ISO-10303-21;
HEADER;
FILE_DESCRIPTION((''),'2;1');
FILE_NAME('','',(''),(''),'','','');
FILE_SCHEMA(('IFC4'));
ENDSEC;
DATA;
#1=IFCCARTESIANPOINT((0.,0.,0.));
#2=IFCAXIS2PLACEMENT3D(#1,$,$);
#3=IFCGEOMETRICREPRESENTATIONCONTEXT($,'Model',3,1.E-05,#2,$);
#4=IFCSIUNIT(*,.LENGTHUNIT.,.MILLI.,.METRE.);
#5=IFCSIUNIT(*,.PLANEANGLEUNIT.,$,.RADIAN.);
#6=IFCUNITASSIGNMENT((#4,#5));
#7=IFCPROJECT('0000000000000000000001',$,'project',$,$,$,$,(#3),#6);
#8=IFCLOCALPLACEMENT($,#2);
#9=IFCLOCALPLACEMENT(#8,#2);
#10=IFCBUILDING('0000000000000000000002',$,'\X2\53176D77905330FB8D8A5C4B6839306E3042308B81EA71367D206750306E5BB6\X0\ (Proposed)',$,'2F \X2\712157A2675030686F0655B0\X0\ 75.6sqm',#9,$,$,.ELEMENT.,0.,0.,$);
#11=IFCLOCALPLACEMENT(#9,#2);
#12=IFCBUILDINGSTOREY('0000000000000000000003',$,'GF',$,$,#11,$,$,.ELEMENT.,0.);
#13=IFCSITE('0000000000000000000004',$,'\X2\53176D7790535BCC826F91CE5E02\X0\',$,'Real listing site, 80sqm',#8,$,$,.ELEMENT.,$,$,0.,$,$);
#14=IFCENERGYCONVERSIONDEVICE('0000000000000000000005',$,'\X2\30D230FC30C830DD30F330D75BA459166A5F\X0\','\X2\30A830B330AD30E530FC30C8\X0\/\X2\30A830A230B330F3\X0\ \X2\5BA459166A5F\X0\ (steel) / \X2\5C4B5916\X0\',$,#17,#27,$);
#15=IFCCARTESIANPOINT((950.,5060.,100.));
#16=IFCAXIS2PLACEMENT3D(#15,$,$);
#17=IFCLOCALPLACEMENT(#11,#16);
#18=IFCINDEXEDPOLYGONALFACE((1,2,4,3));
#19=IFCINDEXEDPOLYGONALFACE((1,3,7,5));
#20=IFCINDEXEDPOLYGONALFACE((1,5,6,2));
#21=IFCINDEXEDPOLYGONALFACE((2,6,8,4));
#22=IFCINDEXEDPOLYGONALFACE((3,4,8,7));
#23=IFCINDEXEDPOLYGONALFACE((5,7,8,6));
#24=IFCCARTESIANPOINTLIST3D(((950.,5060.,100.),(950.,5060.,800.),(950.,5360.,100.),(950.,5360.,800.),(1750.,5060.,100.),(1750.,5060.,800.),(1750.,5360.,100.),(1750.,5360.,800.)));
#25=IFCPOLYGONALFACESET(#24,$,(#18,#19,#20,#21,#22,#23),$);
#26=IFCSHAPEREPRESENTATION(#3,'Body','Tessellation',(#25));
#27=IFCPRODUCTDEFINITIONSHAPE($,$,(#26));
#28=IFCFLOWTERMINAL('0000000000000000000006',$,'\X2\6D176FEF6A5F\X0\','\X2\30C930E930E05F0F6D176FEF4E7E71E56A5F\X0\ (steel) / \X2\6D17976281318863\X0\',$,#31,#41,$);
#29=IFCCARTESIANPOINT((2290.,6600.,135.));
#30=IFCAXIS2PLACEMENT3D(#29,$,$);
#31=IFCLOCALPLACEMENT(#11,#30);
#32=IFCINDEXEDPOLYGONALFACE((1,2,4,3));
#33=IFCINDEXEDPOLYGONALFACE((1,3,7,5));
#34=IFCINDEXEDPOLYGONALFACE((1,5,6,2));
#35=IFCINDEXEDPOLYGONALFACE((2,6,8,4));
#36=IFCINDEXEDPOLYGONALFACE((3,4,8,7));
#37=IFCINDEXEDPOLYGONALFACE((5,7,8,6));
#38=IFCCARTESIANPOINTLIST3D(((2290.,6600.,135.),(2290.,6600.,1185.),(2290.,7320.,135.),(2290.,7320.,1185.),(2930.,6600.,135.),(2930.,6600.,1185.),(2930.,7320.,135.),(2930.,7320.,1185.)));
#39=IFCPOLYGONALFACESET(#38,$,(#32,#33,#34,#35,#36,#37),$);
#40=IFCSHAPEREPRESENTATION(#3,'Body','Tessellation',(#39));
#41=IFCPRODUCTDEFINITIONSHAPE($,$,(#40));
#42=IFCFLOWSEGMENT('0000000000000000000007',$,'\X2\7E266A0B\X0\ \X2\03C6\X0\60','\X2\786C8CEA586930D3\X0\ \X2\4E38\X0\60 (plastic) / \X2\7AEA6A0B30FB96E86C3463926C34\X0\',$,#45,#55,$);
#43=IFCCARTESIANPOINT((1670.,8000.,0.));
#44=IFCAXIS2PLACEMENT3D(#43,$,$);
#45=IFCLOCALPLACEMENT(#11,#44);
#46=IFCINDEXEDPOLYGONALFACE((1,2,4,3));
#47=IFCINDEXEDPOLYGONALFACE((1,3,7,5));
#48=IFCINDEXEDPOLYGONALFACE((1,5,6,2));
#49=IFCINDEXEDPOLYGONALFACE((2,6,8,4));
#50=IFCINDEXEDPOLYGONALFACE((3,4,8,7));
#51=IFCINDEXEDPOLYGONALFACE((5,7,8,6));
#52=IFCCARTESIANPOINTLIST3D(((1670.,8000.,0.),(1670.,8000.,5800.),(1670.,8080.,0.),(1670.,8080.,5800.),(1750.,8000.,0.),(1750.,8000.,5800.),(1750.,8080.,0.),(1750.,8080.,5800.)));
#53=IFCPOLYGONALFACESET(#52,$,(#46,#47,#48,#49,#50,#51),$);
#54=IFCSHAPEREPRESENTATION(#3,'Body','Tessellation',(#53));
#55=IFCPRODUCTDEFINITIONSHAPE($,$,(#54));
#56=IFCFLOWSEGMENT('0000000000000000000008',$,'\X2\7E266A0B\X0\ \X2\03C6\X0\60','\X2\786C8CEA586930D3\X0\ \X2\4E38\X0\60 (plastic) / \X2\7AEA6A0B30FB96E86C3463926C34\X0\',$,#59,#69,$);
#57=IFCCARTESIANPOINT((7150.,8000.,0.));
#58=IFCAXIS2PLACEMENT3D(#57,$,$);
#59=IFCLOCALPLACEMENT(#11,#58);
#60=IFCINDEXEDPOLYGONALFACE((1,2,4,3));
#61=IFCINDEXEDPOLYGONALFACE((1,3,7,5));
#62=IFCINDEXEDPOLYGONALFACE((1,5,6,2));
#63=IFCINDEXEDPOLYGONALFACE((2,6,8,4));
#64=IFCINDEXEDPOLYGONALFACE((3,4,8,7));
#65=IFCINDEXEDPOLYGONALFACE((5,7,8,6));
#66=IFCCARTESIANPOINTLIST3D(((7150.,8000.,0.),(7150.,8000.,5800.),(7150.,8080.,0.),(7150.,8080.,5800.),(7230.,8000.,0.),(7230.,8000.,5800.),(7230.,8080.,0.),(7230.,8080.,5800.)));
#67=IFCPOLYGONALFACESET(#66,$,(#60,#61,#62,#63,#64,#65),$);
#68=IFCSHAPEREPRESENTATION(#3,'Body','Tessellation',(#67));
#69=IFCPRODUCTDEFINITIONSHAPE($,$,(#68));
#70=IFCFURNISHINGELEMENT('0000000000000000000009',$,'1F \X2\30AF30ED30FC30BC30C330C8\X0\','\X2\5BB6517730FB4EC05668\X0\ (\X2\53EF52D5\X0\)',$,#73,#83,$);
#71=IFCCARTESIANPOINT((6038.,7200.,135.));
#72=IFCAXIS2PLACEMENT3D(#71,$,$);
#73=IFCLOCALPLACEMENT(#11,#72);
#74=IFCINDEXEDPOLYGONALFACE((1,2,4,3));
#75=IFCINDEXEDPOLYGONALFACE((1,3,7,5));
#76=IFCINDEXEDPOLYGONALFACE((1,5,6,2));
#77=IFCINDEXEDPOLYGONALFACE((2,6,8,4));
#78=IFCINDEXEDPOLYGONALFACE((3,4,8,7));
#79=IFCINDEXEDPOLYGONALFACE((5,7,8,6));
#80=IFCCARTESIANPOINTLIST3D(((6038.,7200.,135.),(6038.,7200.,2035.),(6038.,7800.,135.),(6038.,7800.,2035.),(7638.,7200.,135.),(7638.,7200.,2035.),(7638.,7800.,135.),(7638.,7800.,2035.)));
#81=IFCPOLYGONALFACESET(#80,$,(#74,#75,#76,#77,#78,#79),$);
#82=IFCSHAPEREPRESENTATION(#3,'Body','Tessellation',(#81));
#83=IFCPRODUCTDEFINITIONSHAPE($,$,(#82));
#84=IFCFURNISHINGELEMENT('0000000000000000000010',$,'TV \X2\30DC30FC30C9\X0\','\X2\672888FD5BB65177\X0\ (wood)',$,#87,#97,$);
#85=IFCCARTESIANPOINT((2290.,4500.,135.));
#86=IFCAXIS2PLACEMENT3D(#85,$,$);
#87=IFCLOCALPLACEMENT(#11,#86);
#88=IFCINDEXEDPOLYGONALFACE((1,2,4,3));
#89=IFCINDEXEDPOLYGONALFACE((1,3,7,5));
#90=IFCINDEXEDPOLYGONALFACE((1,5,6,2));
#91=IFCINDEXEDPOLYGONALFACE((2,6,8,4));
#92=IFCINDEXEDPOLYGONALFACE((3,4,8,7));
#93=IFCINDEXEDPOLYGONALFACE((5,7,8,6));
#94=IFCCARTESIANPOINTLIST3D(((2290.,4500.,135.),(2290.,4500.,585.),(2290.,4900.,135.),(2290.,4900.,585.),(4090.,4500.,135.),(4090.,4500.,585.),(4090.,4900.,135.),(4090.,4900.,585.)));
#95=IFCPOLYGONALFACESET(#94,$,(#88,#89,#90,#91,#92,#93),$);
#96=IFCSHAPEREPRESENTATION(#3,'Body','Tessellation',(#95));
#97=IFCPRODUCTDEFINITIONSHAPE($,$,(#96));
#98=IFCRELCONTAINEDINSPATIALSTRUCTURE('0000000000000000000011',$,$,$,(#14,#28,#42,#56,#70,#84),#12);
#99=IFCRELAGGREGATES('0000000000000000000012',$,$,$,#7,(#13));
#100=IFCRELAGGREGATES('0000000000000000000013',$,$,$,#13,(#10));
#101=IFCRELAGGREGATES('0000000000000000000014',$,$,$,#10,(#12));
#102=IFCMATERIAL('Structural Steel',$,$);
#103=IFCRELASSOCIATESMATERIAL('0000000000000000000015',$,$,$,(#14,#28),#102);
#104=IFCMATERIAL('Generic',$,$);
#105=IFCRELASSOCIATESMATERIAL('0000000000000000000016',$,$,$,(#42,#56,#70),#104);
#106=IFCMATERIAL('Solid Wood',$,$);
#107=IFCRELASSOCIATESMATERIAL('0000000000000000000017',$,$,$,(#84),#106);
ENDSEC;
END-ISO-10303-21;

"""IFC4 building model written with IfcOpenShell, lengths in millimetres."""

from ifc_helpers import new_model, si_unit, frame, frame_2d, origin, place, context, project, spatial, rectangle, extrude, material, element, save


model = new_model("IFC4")

# Units and contexts
model_context = context("Model", 3, precision=1e-05, world=origin())
ifc_project = project(units=[si_unit("LENGTHUNIT", "METRE", prefix="MILLI"), si_unit("PLANEANGLEUNIT", "RADIAN")], contexts=[model_context])

# Site, building, storey
site_placement = place(None, origin())
site = spatial("IfcSite", under=ifc_project, at=site_placement, Name="北海道富良野市", ObjectType="Real listing site, 80sqm", CompositionType="ELEMENT", RefElevation=0.0)
building_placement = place(site_placement, origin())
building = spatial("IfcBuilding", under=site, at=building_placement, Name="北海道・越屋根のある自然素材の家 (Proposed)", ObjectType="2F 無垢材と漆喰 75.6sqm", CompositionType="ELEMENT", ElevationOfRefHeight=0.0, ElevationOfTerrain=0.0)
storey_placement = place(building_placement, origin())
storey = spatial("IfcBuildingStorey", under=building, at=storey_placement, Name="GF", CompositionType="ELEMENT", Elevation=0.0)

# Shared definitions
ifc_material_1 = material(Name="Solid Wood")

# Shared definitions
ifc_material_2 = material(Name="Generic")

# Shared definitions
ifc_material_3 = material(Name="Structural Steel")

# Energy conversion device
energy_conversion_device_placement = place(storey_placement, frame((950.0, 5060.0, 100.0)))
element("IfcEnergyConversionDevice", 1, at=energy_conversion_device_placement, inside=storey, material=ifc_material_3, Name="ヒートポンプ室外機", Description="エコキュート/エアコン 室外機 (steel) / 屋外", context=model_context, shape_type="SweptSolid", body=[
    extrude(rectangle(XDim=800.0, YDim=300.0, at=frame_2d((400.0, 150.0))), frame((950.0, 5060.0, 100.0)), (0.0, 0.0, 1.0), 700.0),
])

# Flow terminal
flow_terminal_placement = place(storey_placement, frame((2290.0, 6600.0, 135.0)))
element("IfcFlowTerminal", 2, at=flow_terminal_placement, inside=storey, material=ifc_material_3, Name="洗濯機", Description="ドラム式洗濯乾燥機 (steel) / 洗面脱衣", context=model_context, shape_type="SweptSolid", body=[
    extrude(rectangle(XDim=640.0, YDim=720.0, at=frame_2d((320.0, 360.0))), frame((2290.0, 6600.0, 135.0)), (0.0, 0.0, 1.0), 1050.0),
])

# Flow segments
flow_segment_1_placement = place(storey_placement, frame((1670.0, 8000.0, 0.0)))
element("IfcFlowSegment", 3, at=flow_segment_1_placement, inside=storey, material=ifc_material_2, Name="縦樋 φ60", Description="硬質塩ビ 丸60 (plastic) / 竪樋・雨水排水", context=model_context, shape_type="SweptSolid", body=[
    extrude(rectangle(XDim=80.0, YDim=80.0, at=frame_2d((40.0, 40.0))), frame((1670.0, 8000.0, 0.0)), (0.0, 0.0, 1.0), 5800.0),
])
flow_segment_2_placement = place(storey_placement, frame((7150.0, 8000.0, 0.0)))
element("IfcFlowSegment", 4, at=flow_segment_2_placement, inside=storey, material=ifc_material_2, Name="縦樋 φ60", Description="硬質塩ビ 丸60 (plastic) / 竪樋・雨水排水", context=model_context, shape_type="SweptSolid", body=[
    extrude(rectangle(XDim=80.0, YDim=80.0, at=frame_2d((40.0, 40.0))), frame((7150.0, 8000.0, 0.0)), (0.0, 0.0, 1.0), 5800.0),
])

# Furnishing elements
furnishing_1_placement = place(storey_placement, frame((6038.0, 7200.0, 135.0)))
element("IfcFurnishingElement", 5, at=furnishing_1_placement, inside=storey, material=ifc_material_2, Name="1F クローゼット", Description="家具・什器 (可動)", context=model_context, shape_type="SweptSolid", body=[
    extrude(rectangle(XDim=1600.0, YDim=600.0, at=frame_2d((800.0, 300.0))), frame((6038.0, 7200.0, 135.0)), (0.0, 0.0, 1.0), 1900.0),
])
furnishing_2_placement = place(storey_placement, frame((2290.0, 4500.0, 135.0)))
element("IfcFurnishingElement", 6, at=furnishing_2_placement, inside=storey, material=ifc_material_1, Name="TV ボード", Description="木製家具 (wood)", context=model_context, shape_type="SweptSolid", body=[
    extrude(rectangle(XDim=1800.0, YDim=400.0, at=frame_2d((900.0, 200.0))), frame((2290.0, 4500.0, 135.0)), (0.0, 0.0, 1.0), 450.0),
])

save(model, "model.ifc")
